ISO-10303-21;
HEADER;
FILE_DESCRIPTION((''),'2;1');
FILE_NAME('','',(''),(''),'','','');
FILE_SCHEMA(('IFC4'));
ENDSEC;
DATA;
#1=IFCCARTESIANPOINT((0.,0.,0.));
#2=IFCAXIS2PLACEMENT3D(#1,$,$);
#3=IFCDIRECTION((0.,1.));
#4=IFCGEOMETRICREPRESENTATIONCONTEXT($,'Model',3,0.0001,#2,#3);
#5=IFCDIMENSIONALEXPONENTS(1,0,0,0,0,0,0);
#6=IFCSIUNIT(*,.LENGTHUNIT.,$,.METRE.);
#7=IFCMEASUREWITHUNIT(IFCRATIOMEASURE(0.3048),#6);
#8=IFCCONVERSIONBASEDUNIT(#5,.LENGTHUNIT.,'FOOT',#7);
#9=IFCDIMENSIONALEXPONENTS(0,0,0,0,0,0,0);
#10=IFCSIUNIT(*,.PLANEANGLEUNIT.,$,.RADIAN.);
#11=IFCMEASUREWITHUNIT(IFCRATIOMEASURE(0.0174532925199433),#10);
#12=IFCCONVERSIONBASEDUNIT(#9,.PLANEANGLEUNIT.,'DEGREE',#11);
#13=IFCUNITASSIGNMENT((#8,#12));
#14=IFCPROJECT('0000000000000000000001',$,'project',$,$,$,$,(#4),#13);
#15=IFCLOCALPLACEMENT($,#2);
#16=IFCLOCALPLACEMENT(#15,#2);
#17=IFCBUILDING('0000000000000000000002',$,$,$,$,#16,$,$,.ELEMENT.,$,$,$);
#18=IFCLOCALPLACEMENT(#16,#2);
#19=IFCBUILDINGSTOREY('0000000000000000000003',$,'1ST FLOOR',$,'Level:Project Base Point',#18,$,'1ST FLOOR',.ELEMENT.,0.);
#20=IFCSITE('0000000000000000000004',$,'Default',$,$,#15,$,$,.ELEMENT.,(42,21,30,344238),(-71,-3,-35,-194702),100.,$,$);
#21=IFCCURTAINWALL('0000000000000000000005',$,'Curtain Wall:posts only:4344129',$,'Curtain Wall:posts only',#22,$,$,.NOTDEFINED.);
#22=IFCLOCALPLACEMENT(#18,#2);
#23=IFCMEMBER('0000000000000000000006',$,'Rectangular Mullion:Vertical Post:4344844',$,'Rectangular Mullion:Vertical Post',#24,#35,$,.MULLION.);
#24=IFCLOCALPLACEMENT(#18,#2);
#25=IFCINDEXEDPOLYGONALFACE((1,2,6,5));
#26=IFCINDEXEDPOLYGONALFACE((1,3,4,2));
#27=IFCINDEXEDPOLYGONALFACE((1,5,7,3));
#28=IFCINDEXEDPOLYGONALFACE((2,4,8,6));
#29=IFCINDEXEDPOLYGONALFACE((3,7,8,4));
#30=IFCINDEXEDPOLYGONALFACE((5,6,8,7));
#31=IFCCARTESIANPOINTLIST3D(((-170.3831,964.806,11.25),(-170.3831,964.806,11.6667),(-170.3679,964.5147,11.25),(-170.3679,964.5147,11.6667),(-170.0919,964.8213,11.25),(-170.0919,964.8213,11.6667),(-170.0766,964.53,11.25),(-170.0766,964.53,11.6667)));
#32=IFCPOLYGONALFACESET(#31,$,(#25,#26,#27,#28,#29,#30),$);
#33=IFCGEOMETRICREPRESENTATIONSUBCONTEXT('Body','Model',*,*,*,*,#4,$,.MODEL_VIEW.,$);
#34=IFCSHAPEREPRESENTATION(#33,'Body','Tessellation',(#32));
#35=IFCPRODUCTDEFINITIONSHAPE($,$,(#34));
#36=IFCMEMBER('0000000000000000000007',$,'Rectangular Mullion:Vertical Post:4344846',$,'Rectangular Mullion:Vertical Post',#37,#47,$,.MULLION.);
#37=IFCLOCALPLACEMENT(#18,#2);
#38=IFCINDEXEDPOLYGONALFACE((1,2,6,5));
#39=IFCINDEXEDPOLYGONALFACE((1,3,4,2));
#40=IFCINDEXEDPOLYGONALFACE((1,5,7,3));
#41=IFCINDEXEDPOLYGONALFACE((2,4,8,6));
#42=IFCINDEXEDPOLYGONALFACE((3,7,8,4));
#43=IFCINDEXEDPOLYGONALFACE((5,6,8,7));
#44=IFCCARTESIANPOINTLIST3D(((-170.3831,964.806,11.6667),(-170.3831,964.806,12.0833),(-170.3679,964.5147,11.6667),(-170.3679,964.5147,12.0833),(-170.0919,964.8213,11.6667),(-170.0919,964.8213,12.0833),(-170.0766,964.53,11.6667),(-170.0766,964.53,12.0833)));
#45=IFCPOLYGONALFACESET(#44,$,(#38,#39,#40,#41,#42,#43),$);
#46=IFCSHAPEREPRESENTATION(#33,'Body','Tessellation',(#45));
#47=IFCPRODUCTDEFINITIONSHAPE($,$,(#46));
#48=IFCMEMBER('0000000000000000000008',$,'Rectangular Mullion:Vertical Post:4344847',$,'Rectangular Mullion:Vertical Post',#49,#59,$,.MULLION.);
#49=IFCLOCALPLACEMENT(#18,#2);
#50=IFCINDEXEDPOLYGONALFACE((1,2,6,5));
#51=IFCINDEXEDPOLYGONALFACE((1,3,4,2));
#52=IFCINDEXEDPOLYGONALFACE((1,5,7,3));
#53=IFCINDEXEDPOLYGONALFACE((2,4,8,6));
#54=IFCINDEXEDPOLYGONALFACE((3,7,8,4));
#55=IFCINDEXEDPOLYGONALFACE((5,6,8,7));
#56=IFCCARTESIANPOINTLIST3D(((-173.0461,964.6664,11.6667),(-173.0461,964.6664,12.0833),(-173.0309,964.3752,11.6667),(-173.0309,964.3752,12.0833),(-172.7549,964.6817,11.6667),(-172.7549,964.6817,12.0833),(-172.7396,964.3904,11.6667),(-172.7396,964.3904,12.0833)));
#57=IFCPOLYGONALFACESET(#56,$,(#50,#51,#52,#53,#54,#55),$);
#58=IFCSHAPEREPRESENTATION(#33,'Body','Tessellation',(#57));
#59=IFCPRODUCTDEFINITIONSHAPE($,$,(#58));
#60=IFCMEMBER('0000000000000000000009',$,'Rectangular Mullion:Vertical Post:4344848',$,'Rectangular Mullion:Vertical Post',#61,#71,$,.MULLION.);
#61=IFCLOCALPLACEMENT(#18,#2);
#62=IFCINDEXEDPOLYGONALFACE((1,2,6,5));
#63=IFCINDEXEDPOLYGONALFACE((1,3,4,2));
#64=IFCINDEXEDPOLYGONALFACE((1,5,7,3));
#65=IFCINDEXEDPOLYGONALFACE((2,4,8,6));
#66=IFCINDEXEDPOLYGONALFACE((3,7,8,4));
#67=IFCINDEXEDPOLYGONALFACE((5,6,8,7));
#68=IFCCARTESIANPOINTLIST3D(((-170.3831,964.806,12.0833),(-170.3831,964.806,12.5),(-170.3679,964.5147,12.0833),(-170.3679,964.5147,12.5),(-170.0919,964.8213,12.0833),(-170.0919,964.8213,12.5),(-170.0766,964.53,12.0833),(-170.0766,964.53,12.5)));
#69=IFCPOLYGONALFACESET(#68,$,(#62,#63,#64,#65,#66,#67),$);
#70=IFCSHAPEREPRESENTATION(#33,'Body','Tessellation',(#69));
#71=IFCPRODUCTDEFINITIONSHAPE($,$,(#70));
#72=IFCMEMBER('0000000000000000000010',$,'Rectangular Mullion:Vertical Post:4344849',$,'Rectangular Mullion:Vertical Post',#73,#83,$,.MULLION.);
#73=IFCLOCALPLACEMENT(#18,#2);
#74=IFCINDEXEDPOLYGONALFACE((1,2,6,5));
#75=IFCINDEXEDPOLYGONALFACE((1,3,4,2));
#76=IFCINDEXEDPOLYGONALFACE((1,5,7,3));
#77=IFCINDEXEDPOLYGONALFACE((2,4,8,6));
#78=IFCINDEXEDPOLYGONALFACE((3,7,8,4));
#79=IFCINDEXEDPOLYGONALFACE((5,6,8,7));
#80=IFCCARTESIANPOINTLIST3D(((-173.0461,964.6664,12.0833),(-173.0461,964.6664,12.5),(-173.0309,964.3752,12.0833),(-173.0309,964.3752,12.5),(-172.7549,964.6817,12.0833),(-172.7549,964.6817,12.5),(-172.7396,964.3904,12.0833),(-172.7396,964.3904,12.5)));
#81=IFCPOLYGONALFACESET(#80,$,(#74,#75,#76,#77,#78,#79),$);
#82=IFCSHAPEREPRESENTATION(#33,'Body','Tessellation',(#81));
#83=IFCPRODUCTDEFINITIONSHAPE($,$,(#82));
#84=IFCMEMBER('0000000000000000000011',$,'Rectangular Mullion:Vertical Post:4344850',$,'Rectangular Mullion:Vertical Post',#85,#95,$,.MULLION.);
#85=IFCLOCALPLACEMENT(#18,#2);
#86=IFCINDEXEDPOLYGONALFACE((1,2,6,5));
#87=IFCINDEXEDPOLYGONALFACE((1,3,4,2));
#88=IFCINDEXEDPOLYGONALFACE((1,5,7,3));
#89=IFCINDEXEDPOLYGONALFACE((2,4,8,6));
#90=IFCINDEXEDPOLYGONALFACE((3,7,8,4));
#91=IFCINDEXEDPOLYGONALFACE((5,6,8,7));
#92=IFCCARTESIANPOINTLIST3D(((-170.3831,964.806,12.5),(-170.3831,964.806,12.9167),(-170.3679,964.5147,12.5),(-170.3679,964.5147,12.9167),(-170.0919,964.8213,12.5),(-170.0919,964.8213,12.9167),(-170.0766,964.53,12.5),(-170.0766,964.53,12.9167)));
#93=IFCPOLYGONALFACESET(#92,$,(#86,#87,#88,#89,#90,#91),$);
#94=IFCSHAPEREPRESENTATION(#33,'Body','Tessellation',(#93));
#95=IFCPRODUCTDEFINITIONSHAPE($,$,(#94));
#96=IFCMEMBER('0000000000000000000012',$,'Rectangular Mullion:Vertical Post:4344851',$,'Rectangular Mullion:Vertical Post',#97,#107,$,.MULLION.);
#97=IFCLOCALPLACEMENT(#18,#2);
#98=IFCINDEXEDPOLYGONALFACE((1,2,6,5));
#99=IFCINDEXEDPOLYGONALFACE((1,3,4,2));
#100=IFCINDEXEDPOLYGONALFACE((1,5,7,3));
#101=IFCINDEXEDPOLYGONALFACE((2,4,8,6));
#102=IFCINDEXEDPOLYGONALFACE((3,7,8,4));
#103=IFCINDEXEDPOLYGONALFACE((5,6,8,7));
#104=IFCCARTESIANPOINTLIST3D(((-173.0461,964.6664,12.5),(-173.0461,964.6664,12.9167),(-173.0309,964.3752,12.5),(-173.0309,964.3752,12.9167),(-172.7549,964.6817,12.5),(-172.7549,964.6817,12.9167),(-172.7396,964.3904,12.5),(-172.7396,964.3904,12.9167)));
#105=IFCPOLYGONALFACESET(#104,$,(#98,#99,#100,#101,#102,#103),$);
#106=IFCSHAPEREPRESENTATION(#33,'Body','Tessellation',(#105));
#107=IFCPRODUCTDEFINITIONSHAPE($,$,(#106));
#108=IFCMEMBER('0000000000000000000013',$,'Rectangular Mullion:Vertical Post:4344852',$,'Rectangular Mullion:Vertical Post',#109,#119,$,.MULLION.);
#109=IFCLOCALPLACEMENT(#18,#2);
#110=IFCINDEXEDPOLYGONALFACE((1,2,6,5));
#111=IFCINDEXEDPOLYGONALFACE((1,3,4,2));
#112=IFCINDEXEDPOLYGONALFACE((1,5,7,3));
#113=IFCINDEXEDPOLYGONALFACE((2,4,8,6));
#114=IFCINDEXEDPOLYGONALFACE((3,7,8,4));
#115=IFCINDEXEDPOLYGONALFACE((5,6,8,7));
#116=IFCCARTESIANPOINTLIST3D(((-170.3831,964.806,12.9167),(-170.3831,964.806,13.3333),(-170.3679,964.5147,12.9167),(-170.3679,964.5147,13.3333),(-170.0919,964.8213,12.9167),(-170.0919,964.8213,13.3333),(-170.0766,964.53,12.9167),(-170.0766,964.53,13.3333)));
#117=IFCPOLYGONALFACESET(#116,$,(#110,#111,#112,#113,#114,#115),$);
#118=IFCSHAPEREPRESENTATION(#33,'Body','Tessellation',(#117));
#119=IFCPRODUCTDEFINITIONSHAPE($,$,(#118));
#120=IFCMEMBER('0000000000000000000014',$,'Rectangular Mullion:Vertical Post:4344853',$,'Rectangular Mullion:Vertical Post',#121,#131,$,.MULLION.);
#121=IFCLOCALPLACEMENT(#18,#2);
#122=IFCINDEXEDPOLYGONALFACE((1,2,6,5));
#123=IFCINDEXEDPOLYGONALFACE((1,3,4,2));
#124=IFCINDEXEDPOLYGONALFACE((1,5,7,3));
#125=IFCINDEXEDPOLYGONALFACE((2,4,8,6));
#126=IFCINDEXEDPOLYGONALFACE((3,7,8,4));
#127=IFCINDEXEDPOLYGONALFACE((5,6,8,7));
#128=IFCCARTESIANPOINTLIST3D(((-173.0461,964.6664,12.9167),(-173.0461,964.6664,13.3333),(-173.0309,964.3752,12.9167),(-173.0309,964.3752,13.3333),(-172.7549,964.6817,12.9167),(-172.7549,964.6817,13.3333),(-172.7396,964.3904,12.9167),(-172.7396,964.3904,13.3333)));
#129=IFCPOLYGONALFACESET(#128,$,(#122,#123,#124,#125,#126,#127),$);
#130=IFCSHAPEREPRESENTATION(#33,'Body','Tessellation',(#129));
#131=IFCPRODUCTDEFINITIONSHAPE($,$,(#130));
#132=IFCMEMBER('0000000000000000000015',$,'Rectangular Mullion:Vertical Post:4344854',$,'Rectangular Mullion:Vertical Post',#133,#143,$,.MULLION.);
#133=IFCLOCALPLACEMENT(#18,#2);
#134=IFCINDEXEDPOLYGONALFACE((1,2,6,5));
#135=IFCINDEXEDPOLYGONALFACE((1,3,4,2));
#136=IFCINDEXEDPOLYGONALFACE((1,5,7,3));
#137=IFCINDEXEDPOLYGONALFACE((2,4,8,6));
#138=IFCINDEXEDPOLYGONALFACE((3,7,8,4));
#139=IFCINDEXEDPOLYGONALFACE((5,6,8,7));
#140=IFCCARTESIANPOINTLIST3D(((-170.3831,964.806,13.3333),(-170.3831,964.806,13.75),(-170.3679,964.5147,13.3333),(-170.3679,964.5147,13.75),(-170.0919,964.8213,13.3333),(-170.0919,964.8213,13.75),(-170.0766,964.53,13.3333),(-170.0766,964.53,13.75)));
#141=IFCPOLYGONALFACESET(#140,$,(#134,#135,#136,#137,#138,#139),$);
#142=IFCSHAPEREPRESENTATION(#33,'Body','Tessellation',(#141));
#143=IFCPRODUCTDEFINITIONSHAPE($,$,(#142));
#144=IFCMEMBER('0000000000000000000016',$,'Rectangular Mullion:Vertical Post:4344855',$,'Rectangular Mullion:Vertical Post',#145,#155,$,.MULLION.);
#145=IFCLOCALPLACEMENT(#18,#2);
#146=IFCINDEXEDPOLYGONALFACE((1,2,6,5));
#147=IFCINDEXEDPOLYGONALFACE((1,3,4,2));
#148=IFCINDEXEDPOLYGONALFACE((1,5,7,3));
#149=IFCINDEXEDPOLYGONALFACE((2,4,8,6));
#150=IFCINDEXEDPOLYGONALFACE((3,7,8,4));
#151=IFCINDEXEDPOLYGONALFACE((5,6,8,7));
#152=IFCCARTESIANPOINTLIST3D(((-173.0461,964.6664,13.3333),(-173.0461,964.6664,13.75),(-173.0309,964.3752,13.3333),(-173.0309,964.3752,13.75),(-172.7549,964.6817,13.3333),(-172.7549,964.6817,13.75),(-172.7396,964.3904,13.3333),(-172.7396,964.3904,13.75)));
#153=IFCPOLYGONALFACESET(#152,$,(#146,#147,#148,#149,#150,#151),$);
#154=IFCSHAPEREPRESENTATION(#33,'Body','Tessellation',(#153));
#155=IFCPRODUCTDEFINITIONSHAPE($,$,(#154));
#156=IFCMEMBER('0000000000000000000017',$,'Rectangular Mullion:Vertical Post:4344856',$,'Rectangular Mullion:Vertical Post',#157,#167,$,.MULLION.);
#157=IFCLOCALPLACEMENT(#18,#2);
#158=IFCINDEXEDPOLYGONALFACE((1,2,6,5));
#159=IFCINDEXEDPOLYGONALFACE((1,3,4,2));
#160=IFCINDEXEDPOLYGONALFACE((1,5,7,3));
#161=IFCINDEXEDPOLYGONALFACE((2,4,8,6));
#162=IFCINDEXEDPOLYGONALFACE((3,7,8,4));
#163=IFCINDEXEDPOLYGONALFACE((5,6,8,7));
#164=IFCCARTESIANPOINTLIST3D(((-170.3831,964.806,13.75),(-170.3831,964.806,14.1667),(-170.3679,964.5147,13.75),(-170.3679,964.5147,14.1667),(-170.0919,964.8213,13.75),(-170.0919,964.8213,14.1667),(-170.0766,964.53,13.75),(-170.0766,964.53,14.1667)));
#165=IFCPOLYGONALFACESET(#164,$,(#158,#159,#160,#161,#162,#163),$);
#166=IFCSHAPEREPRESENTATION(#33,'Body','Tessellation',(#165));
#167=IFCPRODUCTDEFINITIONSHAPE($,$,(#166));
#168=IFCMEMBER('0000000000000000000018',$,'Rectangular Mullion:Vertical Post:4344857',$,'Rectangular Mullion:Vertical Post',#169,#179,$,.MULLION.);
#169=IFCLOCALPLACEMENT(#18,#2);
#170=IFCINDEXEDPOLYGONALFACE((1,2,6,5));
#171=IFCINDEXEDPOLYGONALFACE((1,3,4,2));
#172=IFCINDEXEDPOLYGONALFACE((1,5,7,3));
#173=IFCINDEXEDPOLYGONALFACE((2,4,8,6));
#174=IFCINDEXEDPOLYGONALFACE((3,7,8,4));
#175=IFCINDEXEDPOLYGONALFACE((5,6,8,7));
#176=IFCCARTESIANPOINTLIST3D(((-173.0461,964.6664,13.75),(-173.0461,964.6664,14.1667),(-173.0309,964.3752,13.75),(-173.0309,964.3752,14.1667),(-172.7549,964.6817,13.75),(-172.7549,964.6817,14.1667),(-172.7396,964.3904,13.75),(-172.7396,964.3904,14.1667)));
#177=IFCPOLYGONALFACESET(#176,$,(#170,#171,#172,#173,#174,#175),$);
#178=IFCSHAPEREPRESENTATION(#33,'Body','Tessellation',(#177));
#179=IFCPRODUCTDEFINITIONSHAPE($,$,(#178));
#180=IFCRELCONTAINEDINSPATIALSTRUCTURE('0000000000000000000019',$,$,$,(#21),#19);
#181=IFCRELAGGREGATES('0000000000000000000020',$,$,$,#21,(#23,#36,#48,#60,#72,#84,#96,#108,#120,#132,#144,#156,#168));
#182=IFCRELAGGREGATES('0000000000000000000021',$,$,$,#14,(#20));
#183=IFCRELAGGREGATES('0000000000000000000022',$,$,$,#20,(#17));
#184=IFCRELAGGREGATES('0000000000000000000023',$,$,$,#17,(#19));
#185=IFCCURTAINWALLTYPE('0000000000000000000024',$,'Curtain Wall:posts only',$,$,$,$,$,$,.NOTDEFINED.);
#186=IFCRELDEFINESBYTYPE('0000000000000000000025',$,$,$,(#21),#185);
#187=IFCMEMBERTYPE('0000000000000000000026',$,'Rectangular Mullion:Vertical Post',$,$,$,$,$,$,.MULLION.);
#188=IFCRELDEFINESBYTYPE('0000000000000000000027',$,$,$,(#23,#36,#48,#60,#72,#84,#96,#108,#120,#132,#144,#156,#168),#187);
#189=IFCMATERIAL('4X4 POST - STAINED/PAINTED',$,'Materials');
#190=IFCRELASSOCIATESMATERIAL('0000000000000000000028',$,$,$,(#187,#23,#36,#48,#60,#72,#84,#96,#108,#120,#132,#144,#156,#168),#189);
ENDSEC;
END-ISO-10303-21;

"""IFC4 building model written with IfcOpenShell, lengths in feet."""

from ifc_helpers import new_model, entity, si_unit, converted_unit, direction, frame, origin, origin_2d_with_axis, place, context, subcontext, project, spatial, rectangle, extrude, source, transform, mapped, material, material_profile, profile_set, profile_usage, type_object, type_shapes, element, aggregate, save


model = new_model("IFC4")

# Units and contexts
model_context = context("Model", 3, precision=0.0001, world=origin(), true_north=direction((0.0, 1.0)))
body_context = subcontext(model_context, "Body", "Model", "MODEL_VIEW")
ifc_project = project(units=[converted_unit("LENGTHUNIT", "FOOT", entity("IfcRatioMeasure", 0.3048), si_unit("LENGTHUNIT", "METRE"), dimensions=[1, 0, 0, 0, 0, 0, 0]), converted_unit("PLANEANGLEUNIT", "DEGREE", entity("IfcRatioMeasure", 0.0174532925199433), si_unit("PLANEANGLEUNIT", "RADIAN"), dimensions=[0, 0, 0, 0, 0, 0, 0])], contexts=[model_context])

# Site, building, storey
site_placement = place(None, origin())
site = spatial("IfcSite", under=ifc_project, at=site_placement, Name="Default", CompositionType="ELEMENT", RefLatitude=(42, 21, 30, 344238), RefLongitude=(-71, -3, -35, -194702), RefElevation=100.0)
building_placement = place(site_placement, origin())
building = spatial("IfcBuilding", under=site, at=building_placement, CompositionType="ELEMENT")
storey_placement = place(building_placement, origin())
storey = spatial("IfcBuildingStorey", under=building, at=storey_placement, Name="1ST FLOOR", ObjectType="Level:Project Base Point", LongName="1ST FLOOR", CompositionType="ELEMENT", Elevation=0.0)

# Curtain wall, members
curtain_wall_type_1 = type_object("IfcCurtainWallType", Name="Curtain Wall:posts only", PredefinedType="NOTDEFINED")
curtain_wall_1_placement = place(storey_placement, origin())
curtain_wall_1 = element("IfcCurtainWall", 1, at=curtain_wall_1_placement, inside=storey, type_object=curtain_wall_type_1, Name="Curtain Wall:posts only:4344129", ObjectType="Curtain Wall:posts only", PredefinedType="NOTDEFINED")
ifc_material_1 = material(Name="4X4 POST - STAINED/PAINTED", Category="Materials")
ifc_material_profile_1 = material_profile(ifc_material_1, rectangle(XDim=0.2917, YDim=0.2917, at=origin_2d_with_axis()), Name="Vertical Post")
ifc_profile_set_1 = profile_set([ifc_material_profile_1], Name="Vertical Post")
ifc_profile_usage_1 = profile_usage(ifc_profile_set_1)
member_type_1 = type_object("IfcMemberType", Name="Rectangular Mullion:Vertical Post", PredefinedType="MULLION", material=ifc_profile_set_1)
shared_shape_1 = source(origin(), body_context, "Body", "SweptSolid", [
    extrude(rectangle(XDim=0.2917, YDim=0.2917, at=origin_2d_with_axis()), frame((0.0, -0.2083, -0.4167), z_axis=(0.0, 0.0, 1.0), x_axis=(0.0, -1.0, 0.0)), (0.0, 0.0, 1.0), 0.4167),
])
type_shapes(member_type_1, [shared_shape_1])
member_1_placement = place(storey_placement, frame((-170.2408, 964.8761, 11.25), z_axis=(0.0, 0.0, -1.0), x_axis=(-0.99863, -0.052336, 0.0)))
member_1 = element("IfcMember", 2, at=member_1_placement, type_object=member_type_1, material=ifc_profile_usage_1, Name="Rectangular Mullion:Vertical Post:4344844", ObjectType="Rectangular Mullion:Vertical Post", PredefinedType="MULLION", context=body_context, shape_type="MappedRepresentation", body=[
    mapped(shared_shape_1, transform((0.0, 0.0, 0.0), scale=1.0)),
])
ifc_profile_usage_2 = profile_usage(ifc_profile_set_1)
member_2_placement = place(storey_placement, frame((-170.2408, 964.8761, 11.6667), z_axis=(0.0, 0.0, -1.0), x_axis=(-0.99863, -0.052336, 0.0)))
member_2 = element("IfcMember", 3, at=member_2_placement, type_object=member_type_1, material=ifc_profile_usage_2, Name="Rectangular Mullion:Vertical Post:4344846", ObjectType="Rectangular Mullion:Vertical Post", PredefinedType="MULLION", context=body_context, shape_type="MappedRepresentation", body=[
    mapped(shared_shape_1, transform((0.0, 0.0, 0.0), scale=1.0)),
])
ifc_profile_usage_3 = profile_usage(ifc_profile_set_1)
member_3_placement = place(storey_placement, frame((-172.9038, 964.7365, 11.6667), z_axis=(0.0, 0.0, -1.0), x_axis=(-0.99863, -0.052336, 0.0)))
member_3 = element("IfcMember", 4, at=member_3_placement, type_object=member_type_1, material=ifc_profile_usage_3, Name="Rectangular Mullion:Vertical Post:4344847", ObjectType="Rectangular Mullion:Vertical Post", PredefinedType="MULLION", context=body_context, shape_type="MappedRepresentation", body=[
    mapped(shared_shape_1, transform((0.0, 0.0, 0.0), scale=1.0)),
])
ifc_profile_usage_4 = profile_usage(ifc_profile_set_1)
member_4_placement = place(storey_placement, frame((-170.2408, 964.8761, 12.0833), z_axis=(0.0, 0.0, -1.0), x_axis=(-0.99863, -0.052336, 0.0)))
member_4 = element("IfcMember", 5, at=member_4_placement, type_object=member_type_1, material=ifc_profile_usage_4, Name="Rectangular Mullion:Vertical Post:4344848", ObjectType="Rectangular Mullion:Vertical Post", PredefinedType="MULLION", context=body_context, shape_type="MappedRepresentation", body=[
    mapped(shared_shape_1, transform((0.0, 0.0, 0.0), scale=1.0)),
])
ifc_profile_usage_5 = profile_usage(ifc_profile_set_1)
member_5_placement = place(storey_placement, frame((-172.9038, 964.7365, 12.0833), z_axis=(0.0, 0.0, -1.0), x_axis=(-0.99863, -0.052336, 0.0)))
member_5 = element("IfcMember", 6, at=member_5_placement, type_object=member_type_1, material=ifc_profile_usage_5, Name="Rectangular Mullion:Vertical Post:4344849", ObjectType="Rectangular Mullion:Vertical Post", PredefinedType="MULLION", context=body_context, shape_type="MappedRepresentation", body=[
    mapped(shared_shape_1, transform((0.0, 0.0, 0.0), scale=1.0)),
])
ifc_profile_usage_6 = profile_usage(ifc_profile_set_1)
member_6_placement = place(storey_placement, frame((-170.2408, 964.8761, 12.5), z_axis=(0.0, 0.0, -1.0), x_axis=(-0.99863, -0.052336, 0.0)))
member_6 = element("IfcMember", 7, at=member_6_placement, type_object=member_type_1, material=ifc_profile_usage_6, Name="Rectangular Mullion:Vertical Post:4344850", ObjectType="Rectangular Mullion:Vertical Post", PredefinedType="MULLION", context=body_context, shape_type="MappedRepresentation", body=[
    mapped(shared_shape_1, transform((0.0, 0.0, 0.0), scale=1.0)),
])
ifc_profile_usage_7 = profile_usage(ifc_profile_set_1)
member_7_placement = place(storey_placement, frame((-172.9038, 964.7365, 12.5), z_axis=(0.0, 0.0, -1.0), x_axis=(-0.99863, -0.052336, 0.0)))
member_7 = element("IfcMember", 8, at=member_7_placement, type_object=member_type_1, material=ifc_profile_usage_7, Name="Rectangular Mullion:Vertical Post:4344851", ObjectType="Rectangular Mullion:Vertical Post", PredefinedType="MULLION", context=body_context, shape_type="MappedRepresentation", body=[
    mapped(shared_shape_1, transform((0.0, 0.0, 0.0), scale=1.0)),
])
ifc_profile_usage_8 = profile_usage(ifc_profile_set_1)
member_8_placement = place(storey_placement, frame((-170.2408, 964.8761, 12.9167), z_axis=(0.0, 0.0, -1.0), x_axis=(-0.99863, -0.052336, 0.0)))
member_8 = element("IfcMember", 9, at=member_8_placement, type_object=member_type_1, material=ifc_profile_usage_8, Name="Rectangular Mullion:Vertical Post:4344852", ObjectType="Rectangular Mullion:Vertical Post", PredefinedType="MULLION", context=body_context, shape_type="MappedRepresentation", body=[
    mapped(shared_shape_1, transform((0.0, 0.0, 0.0), scale=1.0)),
])
ifc_profile_usage_9 = profile_usage(ifc_profile_set_1)
member_9_placement = place(storey_placement, frame((-172.9038, 964.7365, 12.9167), z_axis=(0.0, 0.0, -1.0), x_axis=(-0.99863, -0.052336, 0.0)))
member_9 = element("IfcMember", 10, at=member_9_placement, type_object=member_type_1, material=ifc_profile_usage_9, Name="Rectangular Mullion:Vertical Post:4344853", ObjectType="Rectangular Mullion:Vertical Post", PredefinedType="MULLION", context=body_context, shape_type="MappedRepresentation", body=[
    mapped(shared_shape_1, transform((0.0, 0.0, 0.0), scale=1.0)),
])
ifc_profile_usage_10 = profile_usage(ifc_profile_set_1)
member_10_placement = place(storey_placement, frame((-170.2408, 964.8761, 13.3333), z_axis=(0.0, 0.0, -1.0), x_axis=(-0.99863, -0.052336, 0.0)))
member_10 = element("IfcMember", 11, at=member_10_placement, type_object=member_type_1, material=ifc_profile_usage_10, Name="Rectangular Mullion:Vertical Post:4344854", ObjectType="Rectangular Mullion:Vertical Post", PredefinedType="MULLION", context=body_context, shape_type="MappedRepresentation", body=[
    mapped(shared_shape_1, transform((0.0, 0.0, 0.0), scale=1.0)),
])
ifc_profile_usage_11 = profile_usage(ifc_profile_set_1)
member_11_placement = place(storey_placement, frame((-172.9038, 964.7365, 13.3333), z_axis=(0.0, 0.0, -1.0), x_axis=(-0.99863, -0.052336, 0.0)))
member_11 = element("IfcMember", 12, at=member_11_placement, type_object=member_type_1, material=ifc_profile_usage_11, Name="Rectangular Mullion:Vertical Post:4344855", ObjectType="Rectangular Mullion:Vertical Post", PredefinedType="MULLION", context=body_context, shape_type="MappedRepresentation", body=[
    mapped(shared_shape_1, transform((0.0, 0.0, 0.0), scale=1.0)),
])
ifc_profile_usage_12 = profile_usage(ifc_profile_set_1)
member_12_placement = place(storey_placement, frame((-170.2408, 964.8761, 13.75), z_axis=(0.0, 0.0, -1.0), x_axis=(-0.99863, -0.052336, 0.0)))
member_12 = element("IfcMember", 13, at=member_12_placement, type_object=member_type_1, material=ifc_profile_usage_12, Name="Rectangular Mullion:Vertical Post:4344856", ObjectType="Rectangular Mullion:Vertical Post", PredefinedType="MULLION", context=body_context, shape_type="MappedRepresentation", body=[
    mapped(shared_shape_1, transform((0.0, 0.0, 0.0), scale=1.0)),
])
ifc_profile_usage_13 = profile_usage(ifc_profile_set_1)
member_13_placement = place(storey_placement, frame((-172.9038, 964.7365, 13.75), z_axis=(0.0, 0.0, -1.0), x_axis=(-0.99863, -0.052336, 0.0)))
member_13 = element("IfcMember", 14, at=member_13_placement, type_object=member_type_1, material=ifc_profile_usage_13, Name="Rectangular Mullion:Vertical Post:4344857", ObjectType="Rectangular Mullion:Vertical Post", PredefinedType="MULLION", context=body_context, shape_type="MappedRepresentation", body=[
    mapped(shared_shape_1, transform((0.0, 0.0, 0.0), scale=1.0)),
])
aggregate(curtain_wall_1, [member_1, member_2, member_3, member_4, member_5, member_6, member_7, member_8, member_9, member_10, member_11, member_12, member_13])

save(model, "model.ifc")
